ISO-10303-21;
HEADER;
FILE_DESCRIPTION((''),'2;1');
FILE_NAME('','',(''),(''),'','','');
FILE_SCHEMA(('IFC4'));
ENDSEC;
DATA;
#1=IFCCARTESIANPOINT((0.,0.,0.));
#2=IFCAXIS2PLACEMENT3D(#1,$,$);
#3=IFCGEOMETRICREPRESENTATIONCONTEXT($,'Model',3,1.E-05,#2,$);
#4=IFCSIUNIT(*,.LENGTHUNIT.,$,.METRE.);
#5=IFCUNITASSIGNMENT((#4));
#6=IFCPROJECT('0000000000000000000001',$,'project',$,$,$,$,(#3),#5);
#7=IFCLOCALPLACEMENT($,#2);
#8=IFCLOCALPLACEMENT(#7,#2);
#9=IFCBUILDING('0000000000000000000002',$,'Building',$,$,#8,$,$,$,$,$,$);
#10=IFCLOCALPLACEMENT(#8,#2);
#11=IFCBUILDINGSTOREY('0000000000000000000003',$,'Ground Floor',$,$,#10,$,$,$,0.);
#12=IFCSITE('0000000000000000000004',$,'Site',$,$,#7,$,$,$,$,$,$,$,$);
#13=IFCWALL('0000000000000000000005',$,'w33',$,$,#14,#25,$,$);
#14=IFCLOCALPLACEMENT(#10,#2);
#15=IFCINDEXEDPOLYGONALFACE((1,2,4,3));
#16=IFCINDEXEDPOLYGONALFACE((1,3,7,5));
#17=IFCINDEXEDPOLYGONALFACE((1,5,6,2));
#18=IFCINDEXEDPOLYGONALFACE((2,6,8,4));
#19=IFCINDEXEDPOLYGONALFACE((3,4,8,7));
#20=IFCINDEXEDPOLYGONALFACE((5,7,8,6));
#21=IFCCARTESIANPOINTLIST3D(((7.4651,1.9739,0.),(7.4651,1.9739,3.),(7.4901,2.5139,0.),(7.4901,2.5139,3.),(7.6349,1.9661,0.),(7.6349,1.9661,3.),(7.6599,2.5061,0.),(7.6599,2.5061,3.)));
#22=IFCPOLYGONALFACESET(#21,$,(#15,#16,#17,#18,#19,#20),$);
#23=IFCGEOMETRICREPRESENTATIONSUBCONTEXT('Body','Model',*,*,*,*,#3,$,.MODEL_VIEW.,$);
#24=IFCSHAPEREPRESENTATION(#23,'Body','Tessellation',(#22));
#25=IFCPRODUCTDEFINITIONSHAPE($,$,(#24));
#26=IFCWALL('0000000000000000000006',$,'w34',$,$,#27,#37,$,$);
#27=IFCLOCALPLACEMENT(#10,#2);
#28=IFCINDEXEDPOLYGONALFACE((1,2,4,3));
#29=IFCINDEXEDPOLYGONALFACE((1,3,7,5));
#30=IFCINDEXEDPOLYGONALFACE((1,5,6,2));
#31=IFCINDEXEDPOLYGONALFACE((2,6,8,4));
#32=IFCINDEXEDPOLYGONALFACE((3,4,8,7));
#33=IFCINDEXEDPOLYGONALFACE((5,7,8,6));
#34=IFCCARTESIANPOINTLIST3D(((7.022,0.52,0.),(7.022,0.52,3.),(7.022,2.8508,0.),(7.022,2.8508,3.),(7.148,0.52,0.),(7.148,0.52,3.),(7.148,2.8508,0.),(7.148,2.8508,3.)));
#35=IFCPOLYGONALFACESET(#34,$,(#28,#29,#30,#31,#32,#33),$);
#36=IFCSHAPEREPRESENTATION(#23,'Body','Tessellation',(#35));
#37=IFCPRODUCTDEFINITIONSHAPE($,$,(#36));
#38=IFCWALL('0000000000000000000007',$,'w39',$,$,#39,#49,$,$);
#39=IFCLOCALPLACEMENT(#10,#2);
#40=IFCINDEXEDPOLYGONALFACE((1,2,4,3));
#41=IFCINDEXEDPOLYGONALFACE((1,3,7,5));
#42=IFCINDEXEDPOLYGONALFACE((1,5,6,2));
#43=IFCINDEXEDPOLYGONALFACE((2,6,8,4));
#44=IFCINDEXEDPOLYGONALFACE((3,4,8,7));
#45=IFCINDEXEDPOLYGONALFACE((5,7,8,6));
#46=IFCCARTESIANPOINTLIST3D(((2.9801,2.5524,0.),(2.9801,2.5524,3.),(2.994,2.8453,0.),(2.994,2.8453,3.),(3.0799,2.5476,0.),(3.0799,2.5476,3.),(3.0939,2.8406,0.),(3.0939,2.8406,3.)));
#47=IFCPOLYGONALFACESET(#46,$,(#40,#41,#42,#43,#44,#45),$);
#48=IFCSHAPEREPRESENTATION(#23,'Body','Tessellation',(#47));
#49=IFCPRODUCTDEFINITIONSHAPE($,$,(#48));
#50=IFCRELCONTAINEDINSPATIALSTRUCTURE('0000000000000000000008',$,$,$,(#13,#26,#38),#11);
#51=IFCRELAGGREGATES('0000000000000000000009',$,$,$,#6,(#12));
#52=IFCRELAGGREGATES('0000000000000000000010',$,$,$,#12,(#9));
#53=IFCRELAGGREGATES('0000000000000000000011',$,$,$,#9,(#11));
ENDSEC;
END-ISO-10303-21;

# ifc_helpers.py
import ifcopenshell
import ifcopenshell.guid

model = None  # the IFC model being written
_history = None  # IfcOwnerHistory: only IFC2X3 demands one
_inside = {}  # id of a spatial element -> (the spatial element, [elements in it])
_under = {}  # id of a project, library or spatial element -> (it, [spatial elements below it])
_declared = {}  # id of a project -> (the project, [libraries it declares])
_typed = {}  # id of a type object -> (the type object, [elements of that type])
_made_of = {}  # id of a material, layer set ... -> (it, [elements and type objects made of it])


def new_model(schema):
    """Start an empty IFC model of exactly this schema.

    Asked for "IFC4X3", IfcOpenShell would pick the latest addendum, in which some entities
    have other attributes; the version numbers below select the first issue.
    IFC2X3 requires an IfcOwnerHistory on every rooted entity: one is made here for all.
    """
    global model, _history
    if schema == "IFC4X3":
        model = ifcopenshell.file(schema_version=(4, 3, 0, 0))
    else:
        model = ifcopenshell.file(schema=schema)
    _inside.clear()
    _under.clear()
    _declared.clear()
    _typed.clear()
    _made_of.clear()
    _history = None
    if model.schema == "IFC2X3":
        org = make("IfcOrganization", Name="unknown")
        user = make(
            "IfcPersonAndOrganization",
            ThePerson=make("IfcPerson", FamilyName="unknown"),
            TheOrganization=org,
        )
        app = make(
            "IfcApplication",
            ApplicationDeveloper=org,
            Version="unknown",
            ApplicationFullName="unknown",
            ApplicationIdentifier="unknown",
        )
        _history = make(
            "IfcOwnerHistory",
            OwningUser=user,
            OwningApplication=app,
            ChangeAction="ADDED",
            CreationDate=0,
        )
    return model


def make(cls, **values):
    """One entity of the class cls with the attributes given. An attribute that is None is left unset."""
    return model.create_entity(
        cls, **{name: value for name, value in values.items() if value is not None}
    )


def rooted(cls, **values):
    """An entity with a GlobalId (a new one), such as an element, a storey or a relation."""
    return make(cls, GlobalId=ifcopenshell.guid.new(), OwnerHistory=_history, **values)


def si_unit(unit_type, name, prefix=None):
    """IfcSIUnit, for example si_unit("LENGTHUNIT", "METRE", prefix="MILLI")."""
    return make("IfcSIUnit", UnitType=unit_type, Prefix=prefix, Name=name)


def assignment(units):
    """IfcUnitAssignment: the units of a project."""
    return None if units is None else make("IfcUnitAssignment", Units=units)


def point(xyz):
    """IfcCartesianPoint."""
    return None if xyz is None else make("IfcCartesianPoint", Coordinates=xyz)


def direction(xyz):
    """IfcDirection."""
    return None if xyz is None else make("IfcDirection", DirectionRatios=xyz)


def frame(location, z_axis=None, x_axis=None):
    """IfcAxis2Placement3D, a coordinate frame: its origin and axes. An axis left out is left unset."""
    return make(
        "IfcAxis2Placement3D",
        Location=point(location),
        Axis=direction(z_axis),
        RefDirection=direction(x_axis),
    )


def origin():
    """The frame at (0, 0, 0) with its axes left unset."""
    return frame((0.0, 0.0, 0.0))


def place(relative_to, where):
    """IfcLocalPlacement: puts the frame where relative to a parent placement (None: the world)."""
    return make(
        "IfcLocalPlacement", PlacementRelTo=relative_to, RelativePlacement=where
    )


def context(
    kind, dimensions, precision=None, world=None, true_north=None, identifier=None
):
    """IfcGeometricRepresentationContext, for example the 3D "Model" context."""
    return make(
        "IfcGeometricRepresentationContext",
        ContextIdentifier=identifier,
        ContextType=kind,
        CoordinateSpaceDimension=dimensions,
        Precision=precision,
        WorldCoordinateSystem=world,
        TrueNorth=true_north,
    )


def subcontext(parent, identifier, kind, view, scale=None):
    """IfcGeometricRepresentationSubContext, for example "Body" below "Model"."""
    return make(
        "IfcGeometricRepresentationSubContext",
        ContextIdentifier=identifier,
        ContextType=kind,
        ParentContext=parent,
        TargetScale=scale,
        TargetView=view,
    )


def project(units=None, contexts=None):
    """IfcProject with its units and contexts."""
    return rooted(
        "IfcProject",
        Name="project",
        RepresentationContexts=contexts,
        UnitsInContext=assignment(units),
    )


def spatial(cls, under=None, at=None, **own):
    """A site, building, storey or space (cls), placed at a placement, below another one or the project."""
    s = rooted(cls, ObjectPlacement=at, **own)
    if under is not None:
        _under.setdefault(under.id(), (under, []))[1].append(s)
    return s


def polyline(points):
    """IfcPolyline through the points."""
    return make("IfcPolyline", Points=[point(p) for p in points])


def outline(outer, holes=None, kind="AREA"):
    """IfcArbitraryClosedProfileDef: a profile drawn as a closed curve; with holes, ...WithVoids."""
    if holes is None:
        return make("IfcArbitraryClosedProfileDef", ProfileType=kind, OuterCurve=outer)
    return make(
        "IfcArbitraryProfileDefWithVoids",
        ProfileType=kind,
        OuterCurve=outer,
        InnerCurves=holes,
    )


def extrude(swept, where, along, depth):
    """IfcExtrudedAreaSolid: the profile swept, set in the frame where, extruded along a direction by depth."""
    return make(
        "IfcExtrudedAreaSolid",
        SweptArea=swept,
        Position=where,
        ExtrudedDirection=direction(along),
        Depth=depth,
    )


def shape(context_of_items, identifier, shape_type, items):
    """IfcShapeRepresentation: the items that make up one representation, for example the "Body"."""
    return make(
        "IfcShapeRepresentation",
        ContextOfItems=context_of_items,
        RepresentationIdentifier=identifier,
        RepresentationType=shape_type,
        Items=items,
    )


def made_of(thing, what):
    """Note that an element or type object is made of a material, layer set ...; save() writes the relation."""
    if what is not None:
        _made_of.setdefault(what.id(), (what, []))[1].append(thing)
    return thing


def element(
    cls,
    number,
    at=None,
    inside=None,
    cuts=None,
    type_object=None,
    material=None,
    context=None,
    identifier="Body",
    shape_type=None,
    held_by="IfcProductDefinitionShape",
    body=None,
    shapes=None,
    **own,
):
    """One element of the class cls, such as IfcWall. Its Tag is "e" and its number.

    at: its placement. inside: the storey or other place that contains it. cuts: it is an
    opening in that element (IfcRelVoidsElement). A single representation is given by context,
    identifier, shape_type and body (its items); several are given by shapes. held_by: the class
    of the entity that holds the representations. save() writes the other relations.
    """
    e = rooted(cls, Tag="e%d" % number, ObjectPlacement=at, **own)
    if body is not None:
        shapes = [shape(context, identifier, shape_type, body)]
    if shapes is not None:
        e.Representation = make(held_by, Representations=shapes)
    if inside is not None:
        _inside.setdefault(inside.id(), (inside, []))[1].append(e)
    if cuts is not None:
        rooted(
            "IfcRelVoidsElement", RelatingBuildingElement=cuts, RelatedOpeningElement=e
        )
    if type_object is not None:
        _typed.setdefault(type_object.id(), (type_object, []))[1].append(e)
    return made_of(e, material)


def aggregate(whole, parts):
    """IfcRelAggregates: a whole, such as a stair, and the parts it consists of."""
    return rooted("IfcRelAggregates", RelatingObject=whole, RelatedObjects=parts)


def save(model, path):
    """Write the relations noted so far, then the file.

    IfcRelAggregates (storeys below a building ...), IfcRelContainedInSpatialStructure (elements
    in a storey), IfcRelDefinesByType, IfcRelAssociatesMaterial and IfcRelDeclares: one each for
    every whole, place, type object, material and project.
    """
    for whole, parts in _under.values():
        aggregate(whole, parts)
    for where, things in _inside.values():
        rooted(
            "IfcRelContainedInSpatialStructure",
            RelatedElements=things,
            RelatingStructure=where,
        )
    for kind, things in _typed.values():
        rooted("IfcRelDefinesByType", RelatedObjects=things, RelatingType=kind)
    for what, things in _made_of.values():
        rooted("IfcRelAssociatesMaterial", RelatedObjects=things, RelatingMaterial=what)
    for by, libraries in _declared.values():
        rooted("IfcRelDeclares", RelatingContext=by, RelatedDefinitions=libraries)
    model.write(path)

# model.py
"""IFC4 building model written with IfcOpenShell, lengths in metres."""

from ifc_helpers import new_model, si_unit, frame, origin, place, context, subcontext, project, spatial, polyline, outline, extrude, element, save


model = new_model("IFC4")

# Units and contexts
model_context = context("Model", 3, precision=1e-05, world=origin())
body_context = subcontext(model_context, "Body", "Model", "MODEL_VIEW")
ifc_project = project(units=[si_unit("LENGTHUNIT", "METRE")], contexts=[model_context])

# Site, building, storey
site_placement = place(None, origin())
site = spatial("IfcSite", under=ifc_project, at=site_placement, Name="Site")
building_placement = place(site_placement, origin())
building = spatial("IfcBuilding", under=site, at=building_placement, Name="Building")
storey_placement = place(building_placement, origin())
storey = spatial("IfcBuildingStorey", under=building, at=storey_placement, Name="Ground Floor", Elevation=0.0)

# Walls
wall_1_placement = place(storey_placement, frame((7.55, 1.97, 0.0), x_axis=(0.046243, 0.99893, 0.0)))
element("IfcWall", 1, at=wall_1_placement, inside=storey, Name="w33", context=body_context, shape_type="SweptSolid", body=[
    extrude(outline(polyline([(0.0, -0.085), (0.5406, -0.085), (0.5406, 0.085), (0.0, 0.085), (0.0, -0.085)])), origin(), (0.0, 0.0, 1.0), 3.0),
])
wall_2_placement = place(storey_placement, frame((7.085, 0.52, 0.0), x_axis=(0.0, 1.0, 0.0)))
element("IfcWall", 2, at=wall_2_placement, inside=storey, Name="w34", context=body_context, shape_type="SweptSolid", body=[
    extrude(outline(polyline([(0.0, -0.063), (2.3308, -0.063), (2.3308, 0.063), (0.0, 0.063), (0.0, -0.063)])), origin(), (0.0, 0.0, 1.0), 3.0),
])
wall_3_placement = place(storey_placement, frame((3.03, 2.55, 0.0), x_axis=(0.047418, 0.998875, 0.0)))
element("IfcWall", 3, at=wall_3_placement, inside=storey, Name="w39", context=body_context, shape_type="SweptSolid", body=[
    extrude(outline(polyline([(0.0, -0.05), (0.2933, -0.05), (0.2933, 0.05), (0.0, 0.05), (0.0, -0.05)])), origin(), (0.0, 0.0, 1.0), 3.0),
])

save(model, "model.ifc")
